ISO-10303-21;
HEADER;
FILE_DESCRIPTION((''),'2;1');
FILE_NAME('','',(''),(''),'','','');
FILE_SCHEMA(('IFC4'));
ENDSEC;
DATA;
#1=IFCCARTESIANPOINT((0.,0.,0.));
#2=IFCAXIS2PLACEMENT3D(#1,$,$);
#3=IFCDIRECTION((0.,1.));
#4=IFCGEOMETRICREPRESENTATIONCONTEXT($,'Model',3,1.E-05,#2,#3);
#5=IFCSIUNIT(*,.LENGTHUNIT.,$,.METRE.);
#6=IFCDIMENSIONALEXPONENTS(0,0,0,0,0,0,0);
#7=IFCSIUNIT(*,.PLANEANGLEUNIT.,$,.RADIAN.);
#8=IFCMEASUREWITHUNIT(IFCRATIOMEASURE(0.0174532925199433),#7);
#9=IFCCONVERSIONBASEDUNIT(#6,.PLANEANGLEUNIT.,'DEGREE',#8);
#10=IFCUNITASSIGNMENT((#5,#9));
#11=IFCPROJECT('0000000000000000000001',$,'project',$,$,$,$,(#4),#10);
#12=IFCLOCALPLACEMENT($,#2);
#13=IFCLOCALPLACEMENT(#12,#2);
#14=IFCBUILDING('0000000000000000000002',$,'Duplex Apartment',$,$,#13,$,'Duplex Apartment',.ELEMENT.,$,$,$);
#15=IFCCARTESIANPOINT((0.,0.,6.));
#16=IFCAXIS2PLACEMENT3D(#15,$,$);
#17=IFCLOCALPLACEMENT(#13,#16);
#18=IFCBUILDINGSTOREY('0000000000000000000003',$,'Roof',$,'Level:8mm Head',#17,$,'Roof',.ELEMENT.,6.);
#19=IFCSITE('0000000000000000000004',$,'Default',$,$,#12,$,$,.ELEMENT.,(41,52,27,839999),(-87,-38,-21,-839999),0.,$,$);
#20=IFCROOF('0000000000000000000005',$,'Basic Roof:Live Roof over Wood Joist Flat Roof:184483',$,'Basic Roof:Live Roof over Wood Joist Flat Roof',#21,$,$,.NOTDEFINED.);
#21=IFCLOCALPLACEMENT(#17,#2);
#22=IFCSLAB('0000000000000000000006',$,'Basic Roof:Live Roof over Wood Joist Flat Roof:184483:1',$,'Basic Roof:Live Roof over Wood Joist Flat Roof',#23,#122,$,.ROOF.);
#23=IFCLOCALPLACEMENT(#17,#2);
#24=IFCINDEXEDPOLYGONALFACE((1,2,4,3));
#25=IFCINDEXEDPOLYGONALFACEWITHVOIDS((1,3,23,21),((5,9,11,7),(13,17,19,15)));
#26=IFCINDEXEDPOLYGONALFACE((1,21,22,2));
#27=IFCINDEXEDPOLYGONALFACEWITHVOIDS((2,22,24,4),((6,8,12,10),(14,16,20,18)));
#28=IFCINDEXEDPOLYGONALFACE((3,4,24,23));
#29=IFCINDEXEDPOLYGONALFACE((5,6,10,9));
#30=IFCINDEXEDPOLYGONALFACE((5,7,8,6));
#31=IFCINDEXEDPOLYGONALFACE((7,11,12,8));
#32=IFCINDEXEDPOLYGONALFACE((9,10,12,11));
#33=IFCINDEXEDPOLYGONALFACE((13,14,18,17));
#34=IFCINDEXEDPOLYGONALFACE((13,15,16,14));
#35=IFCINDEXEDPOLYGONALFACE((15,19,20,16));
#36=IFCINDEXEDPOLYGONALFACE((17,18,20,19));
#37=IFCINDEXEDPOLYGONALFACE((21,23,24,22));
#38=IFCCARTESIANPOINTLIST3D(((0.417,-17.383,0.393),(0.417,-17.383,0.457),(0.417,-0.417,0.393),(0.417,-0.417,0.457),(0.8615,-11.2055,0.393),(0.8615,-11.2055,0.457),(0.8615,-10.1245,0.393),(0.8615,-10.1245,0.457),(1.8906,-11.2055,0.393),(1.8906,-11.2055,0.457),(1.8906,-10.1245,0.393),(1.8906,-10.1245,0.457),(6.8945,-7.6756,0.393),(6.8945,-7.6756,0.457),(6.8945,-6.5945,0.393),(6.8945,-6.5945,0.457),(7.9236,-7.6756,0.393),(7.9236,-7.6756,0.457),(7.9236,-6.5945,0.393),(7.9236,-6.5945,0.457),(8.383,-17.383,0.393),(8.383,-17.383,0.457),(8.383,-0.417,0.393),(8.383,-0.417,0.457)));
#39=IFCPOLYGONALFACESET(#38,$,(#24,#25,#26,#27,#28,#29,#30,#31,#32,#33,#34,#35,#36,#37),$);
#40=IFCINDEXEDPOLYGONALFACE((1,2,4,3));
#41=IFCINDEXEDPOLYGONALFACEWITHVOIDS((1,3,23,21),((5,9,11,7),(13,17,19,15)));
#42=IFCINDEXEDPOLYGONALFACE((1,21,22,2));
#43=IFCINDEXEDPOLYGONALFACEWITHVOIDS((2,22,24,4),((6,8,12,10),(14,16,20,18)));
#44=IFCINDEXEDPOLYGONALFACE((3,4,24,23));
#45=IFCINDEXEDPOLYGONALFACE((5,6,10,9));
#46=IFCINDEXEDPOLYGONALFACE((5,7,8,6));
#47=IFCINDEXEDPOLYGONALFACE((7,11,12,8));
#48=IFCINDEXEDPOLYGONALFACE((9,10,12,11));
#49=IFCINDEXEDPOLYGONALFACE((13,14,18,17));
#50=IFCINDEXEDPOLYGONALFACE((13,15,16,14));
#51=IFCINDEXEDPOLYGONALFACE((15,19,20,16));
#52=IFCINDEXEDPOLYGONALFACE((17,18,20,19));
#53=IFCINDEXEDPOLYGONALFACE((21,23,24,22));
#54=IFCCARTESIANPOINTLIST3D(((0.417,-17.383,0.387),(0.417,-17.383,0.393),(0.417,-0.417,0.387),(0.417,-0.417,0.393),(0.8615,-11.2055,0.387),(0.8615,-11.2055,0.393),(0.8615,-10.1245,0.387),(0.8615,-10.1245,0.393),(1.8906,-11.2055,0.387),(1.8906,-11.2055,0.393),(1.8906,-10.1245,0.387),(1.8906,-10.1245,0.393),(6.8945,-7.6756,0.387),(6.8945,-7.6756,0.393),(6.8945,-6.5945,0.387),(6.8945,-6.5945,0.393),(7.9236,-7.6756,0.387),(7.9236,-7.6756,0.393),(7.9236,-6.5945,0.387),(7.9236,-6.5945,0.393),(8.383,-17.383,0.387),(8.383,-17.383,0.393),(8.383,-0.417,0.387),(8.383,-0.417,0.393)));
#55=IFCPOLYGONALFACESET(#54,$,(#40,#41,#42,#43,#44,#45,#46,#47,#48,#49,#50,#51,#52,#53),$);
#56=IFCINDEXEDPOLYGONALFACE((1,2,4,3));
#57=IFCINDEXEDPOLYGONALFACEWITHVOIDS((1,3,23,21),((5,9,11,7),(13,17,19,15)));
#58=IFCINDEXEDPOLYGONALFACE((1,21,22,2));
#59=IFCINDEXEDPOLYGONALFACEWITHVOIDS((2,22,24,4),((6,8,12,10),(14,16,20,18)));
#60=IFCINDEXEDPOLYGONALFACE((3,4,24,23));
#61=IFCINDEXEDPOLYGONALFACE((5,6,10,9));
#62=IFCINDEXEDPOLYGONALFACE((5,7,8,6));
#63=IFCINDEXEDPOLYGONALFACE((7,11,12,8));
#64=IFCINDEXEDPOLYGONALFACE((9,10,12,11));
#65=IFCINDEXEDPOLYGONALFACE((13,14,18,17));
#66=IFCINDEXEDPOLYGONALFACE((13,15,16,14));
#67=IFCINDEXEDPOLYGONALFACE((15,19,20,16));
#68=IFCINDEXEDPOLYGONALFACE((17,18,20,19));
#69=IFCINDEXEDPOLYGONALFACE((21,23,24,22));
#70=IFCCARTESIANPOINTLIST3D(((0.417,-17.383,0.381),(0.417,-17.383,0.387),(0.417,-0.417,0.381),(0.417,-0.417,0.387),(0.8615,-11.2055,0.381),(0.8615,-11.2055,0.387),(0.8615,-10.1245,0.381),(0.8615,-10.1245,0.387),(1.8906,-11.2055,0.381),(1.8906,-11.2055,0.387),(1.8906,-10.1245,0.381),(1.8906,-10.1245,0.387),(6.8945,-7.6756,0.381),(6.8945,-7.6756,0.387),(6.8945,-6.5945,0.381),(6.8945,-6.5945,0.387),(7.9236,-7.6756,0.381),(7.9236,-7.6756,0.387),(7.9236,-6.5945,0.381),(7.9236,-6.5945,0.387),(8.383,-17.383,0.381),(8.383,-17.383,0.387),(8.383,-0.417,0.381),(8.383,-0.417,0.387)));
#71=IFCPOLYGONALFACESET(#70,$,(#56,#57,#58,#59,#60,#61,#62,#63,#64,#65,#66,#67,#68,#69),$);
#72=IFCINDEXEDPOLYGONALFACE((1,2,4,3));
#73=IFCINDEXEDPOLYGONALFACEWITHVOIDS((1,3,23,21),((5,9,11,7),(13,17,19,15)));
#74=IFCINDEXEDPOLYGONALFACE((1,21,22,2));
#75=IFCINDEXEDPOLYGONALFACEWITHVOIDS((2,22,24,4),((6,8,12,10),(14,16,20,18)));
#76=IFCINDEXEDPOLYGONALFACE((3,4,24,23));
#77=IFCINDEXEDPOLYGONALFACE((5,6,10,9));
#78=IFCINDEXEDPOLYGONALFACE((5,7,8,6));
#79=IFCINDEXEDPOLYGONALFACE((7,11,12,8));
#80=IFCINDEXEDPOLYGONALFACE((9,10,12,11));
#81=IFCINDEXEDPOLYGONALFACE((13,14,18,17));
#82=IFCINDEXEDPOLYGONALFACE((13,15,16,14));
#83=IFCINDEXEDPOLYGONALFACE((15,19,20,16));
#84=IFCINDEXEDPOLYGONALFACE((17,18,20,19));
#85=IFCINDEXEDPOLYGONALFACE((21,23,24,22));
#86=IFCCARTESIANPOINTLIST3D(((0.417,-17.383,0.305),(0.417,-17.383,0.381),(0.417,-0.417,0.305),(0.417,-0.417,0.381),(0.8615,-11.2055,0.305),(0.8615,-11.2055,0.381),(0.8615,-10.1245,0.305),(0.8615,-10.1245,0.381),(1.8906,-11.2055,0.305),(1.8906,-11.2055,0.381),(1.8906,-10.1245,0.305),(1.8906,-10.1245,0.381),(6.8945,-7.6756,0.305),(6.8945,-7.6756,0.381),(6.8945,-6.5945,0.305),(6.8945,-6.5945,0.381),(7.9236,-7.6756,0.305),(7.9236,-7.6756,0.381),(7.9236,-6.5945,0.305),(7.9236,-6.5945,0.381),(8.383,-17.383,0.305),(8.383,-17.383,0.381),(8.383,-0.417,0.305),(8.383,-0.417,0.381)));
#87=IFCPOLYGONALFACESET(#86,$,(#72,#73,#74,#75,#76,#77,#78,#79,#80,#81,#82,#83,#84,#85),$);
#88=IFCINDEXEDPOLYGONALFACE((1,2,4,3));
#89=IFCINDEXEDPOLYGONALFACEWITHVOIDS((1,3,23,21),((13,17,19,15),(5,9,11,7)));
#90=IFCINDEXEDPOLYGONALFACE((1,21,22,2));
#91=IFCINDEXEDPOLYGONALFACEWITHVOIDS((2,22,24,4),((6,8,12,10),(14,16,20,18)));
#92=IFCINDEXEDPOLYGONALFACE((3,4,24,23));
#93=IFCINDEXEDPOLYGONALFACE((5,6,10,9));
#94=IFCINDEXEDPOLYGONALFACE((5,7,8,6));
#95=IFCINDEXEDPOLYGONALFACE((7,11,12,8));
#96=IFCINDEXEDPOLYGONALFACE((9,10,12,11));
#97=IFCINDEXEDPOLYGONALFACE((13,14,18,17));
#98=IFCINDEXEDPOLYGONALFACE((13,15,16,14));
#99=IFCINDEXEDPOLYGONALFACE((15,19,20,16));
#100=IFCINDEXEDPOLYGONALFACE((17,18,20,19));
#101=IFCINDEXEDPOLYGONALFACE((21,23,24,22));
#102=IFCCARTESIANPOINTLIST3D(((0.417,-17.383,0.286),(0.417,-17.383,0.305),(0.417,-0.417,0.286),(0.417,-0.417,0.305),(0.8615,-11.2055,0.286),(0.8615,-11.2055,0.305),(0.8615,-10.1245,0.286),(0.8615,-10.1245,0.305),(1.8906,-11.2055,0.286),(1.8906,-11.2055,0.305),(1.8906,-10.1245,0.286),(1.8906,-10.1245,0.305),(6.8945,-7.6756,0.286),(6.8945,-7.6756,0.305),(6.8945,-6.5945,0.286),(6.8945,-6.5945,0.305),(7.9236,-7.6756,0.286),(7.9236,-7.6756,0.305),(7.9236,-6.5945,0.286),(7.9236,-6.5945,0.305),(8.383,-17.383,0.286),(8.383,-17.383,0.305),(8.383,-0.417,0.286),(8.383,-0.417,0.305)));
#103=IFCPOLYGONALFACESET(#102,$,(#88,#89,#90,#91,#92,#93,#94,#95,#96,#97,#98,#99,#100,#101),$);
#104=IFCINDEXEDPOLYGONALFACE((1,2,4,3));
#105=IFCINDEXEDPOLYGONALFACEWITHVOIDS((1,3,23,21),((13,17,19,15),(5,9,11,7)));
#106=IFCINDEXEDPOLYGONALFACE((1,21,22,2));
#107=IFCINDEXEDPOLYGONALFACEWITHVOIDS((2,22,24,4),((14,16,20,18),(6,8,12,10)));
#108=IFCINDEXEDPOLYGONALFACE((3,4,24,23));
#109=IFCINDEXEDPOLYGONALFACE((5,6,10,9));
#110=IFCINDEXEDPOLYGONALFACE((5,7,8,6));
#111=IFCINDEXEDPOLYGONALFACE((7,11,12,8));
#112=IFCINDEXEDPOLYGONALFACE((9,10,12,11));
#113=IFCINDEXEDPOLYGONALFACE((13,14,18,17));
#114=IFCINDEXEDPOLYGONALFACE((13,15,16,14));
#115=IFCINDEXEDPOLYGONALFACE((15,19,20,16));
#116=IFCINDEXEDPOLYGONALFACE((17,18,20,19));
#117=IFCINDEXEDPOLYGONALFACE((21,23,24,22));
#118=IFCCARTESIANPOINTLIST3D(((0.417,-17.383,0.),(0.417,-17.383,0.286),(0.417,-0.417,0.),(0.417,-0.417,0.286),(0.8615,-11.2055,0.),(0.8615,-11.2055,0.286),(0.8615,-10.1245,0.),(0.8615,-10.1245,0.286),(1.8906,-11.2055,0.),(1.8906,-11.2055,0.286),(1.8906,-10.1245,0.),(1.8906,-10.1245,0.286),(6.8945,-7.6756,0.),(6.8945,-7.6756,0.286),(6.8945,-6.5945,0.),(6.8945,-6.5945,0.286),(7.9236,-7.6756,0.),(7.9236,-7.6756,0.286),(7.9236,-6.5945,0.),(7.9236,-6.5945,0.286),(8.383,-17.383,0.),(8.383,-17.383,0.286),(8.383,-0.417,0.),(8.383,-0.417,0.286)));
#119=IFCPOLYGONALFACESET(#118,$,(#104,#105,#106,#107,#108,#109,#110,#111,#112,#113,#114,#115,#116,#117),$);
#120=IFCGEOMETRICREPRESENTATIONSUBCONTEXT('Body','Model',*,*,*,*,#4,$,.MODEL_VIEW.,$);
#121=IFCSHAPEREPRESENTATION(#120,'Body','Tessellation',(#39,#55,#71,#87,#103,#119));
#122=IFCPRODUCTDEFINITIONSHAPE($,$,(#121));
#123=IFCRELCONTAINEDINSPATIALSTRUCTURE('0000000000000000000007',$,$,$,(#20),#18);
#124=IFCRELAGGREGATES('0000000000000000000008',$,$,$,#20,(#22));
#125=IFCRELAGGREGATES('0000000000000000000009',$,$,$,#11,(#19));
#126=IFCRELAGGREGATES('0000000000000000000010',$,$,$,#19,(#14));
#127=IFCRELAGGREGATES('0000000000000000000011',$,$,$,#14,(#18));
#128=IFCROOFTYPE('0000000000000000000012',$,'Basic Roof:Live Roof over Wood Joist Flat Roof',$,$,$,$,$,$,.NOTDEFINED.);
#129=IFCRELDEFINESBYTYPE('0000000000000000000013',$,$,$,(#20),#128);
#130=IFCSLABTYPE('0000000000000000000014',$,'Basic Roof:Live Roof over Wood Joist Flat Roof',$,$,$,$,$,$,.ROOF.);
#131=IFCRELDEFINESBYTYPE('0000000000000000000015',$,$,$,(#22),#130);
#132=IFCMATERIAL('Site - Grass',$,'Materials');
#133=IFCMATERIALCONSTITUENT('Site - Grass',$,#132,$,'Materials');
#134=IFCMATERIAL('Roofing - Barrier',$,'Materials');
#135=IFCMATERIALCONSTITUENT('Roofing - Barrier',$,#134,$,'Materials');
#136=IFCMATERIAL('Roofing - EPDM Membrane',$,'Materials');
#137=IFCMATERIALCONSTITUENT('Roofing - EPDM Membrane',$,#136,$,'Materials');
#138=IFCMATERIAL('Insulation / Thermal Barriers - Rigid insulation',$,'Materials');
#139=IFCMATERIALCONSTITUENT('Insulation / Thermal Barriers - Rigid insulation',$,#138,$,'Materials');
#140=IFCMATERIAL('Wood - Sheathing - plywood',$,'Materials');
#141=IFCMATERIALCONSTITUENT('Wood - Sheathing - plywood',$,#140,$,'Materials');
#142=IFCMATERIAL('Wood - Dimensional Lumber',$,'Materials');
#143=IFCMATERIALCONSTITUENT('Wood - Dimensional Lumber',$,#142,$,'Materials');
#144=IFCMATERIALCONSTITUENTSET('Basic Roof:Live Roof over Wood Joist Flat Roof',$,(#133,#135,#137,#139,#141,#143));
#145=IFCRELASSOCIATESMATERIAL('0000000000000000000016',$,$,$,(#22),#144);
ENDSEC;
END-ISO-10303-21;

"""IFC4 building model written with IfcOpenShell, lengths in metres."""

from ifc_helpers import new_model, entity, si_unit, converted_unit, direction, frame, origin, place, context, subcontext, project, spatial, indexed_curve, outline, extrude, material, constituent, constituent_set, type_object, element, aggregate, save


model = new_model("IFC4")

# Units and contexts
model_context = context("Model", 3, precision=1e-05, world=origin(), true_north=direction((0.0, 1.0)))
body_context = subcontext(model_context, "Body", "Model", "MODEL_VIEW")
ifc_project = project(units=[si_unit("LENGTHUNIT", "METRE"), converted_unit("PLANEANGLEUNIT", "DEGREE", entity("IfcRatioMeasure", 0.0174532925199433), si_unit("PLANEANGLEUNIT", "RADIAN"), dimensions=[0, 0, 0, 0, 0, 0, 0])], contexts=[model_context])

# Site, building, storey
site_placement = place(None, origin())
site = spatial("IfcSite", under=ifc_project, at=site_placement, Name="Default", CompositionType="ELEMENT", RefLatitude=(41, 52, 27, 839999), RefLongitude=(-87, -38, -21, -839999), RefElevation=0.0)
building_placement = place(site_placement, origin())
building = spatial("IfcBuilding", under=site, at=building_placement, Name="Duplex Apartment", LongName="Duplex Apartment", CompositionType="ELEMENT")
storey_placement = place(building_placement, frame((0.0, 0.0, 6.0)))
storey = spatial("IfcBuildingStorey", under=building, at=storey_placement, Name="Roof", ObjectType="Level:8mm Head", LongName="Roof", CompositionType="ELEMENT", Elevation=6.0)

# Roof, slab, openings
roof_type = type_object("IfcRoofType", Name="Basic Roof:Live Roof over Wood Joist Flat Roof", PredefinedType="NOTDEFINED")
roof_placement = place(storey_placement, origin())
roof = element("IfcRoof", 1, at=roof_placement, inside=storey, type_object=roof_type, Name="Basic Roof:Live Roof over Wood Joist Flat Roof:184483", ObjectType="Basic Roof:Live Roof over Wood Joist Flat Roof", PredefinedType="NOTDEFINED")
ifc_material_1 = material(Name="Site - Grass", Category="Materials")
ifc_constituent_1 = constituent(ifc_material_1, Name="Site - Grass", Category="Materials")
ifc_material_2 = material(Name="Roofing - Barrier", Category="Materials")
ifc_constituent_2 = constituent(ifc_material_2, Name="Roofing - Barrier", Category="Materials")
ifc_material_3 = material(Name="Roofing - EPDM Membrane", Category="Materials")
ifc_constituent_3 = constituent(ifc_material_3, Name="Roofing - EPDM Membrane", Category="Materials")
ifc_material_4 = material(Name="Insulation / Thermal Barriers - Rigid insulation", Category="Materials")
ifc_constituent_4 = constituent(ifc_material_4, Name="Insulation / Thermal Barriers - Rigid insulation", Category="Materials")
ifc_material_5 = material(Name="Wood - Sheathing - plywood", Category="Materials")
ifc_constituent_5 = constituent(ifc_material_5, Name="Wood - Sheathing - plywood", Category="Materials")
ifc_material_6 = material(Name="Wood - Dimensional Lumber", Category="Materials")
ifc_constituent_6 = constituent(ifc_material_6, Name="Wood - Dimensional Lumber", Category="Materials")
ifc_constituent_set_1 = constituent_set(constituents=[ifc_constituent_1, ifc_constituent_2, ifc_constituent_3, ifc_constituent_4, ifc_constituent_5, ifc_constituent_6], Name="Basic Roof:Live Roof over Wood Joist Flat Roof")
slab_type = type_object("IfcSlabType", Name="Basic Roof:Live Roof over Wood Joist Flat Roof", PredefinedType="ROOF")
slab_placement = place(storey_placement, origin())
slab = element("IfcSlab", 2, at=slab_placement, type_object=slab_type, material=ifc_constituent_set_1, Name="Basic Roof:Live Roof over Wood Joist Flat Roof:184483:1", ObjectType="Basic Roof:Live Roof over Wood Joist Flat Roof", PredefinedType="ROOF", context=body_context, shape_type="SweptSolid", body=[
    extrude(outline(indexed_curve([(-8.483, -3.983), (8.483, -3.983), (8.483, 3.983), (-8.483, 3.983), (-8.483, -3.983)], self_intersect=False)), frame((4.4, -8.9, 0.393), z_axis=(0.0, 0.0, 1.0), x_axis=(0.0, -1.0, 0.0)), (0.0, 0.0, 1.0), 0.064),
    extrude(outline(indexed_curve([(-8.483, -3.983), (8.483, -3.983), (8.483, 3.983), (-8.483, 3.983), (-8.483, -3.983)], self_intersect=False)), frame((4.4, -8.9, 0.387), z_axis=(0.0, 0.0, 1.0), x_axis=(0.0, -1.0, 0.0)), (0.0, 0.0, 1.0), 0.006),
    extrude(outline(indexed_curve([(-8.483, -3.983), (8.483, -3.983), (8.483, 3.983), (-8.483, 3.983), (-8.483, -3.983)], self_intersect=False)), frame((4.4, -8.9, 0.381), z_axis=(0.0, 0.0, 1.0), x_axis=(0.0, -1.0, 0.0)), (0.0, 0.0, 1.0), 0.006),
    extrude(outline(indexed_curve([(-8.483, -3.983), (8.483, -3.983), (8.483, 3.983), (-8.483, 3.983), (-8.483, -3.983)], self_intersect=False)), frame((4.4, -8.9, 0.305), z_axis=(0.0, 0.0, 1.0), x_axis=(0.0, -1.0, 0.0)), (0.0, 0.0, 1.0), 0.076),
    extrude(outline(indexed_curve([(-8.483, -3.983), (8.483, -3.983), (8.483, 3.983), (-8.483, 3.983), (-8.483, -3.983)], self_intersect=False)), frame((4.4, -8.9, 0.286), z_axis=(0.0, 0.0, 1.0), x_axis=(0.0, -1.0, 0.0)), (0.0, 0.0, 1.0), 0.019),
    extrude(outline(indexed_curve([(-8.483, -3.983), (8.483, -3.983), (8.483, 3.983), (-8.483, 3.983), (-8.483, -3.983)], self_intersect=False)), frame((4.4, -8.9, 0.0), z_axis=(0.0, 0.0, 1.0), x_axis=(0.0, -1.0, 0.0)), (0.0, 0.0, 1.0), 0.286),
])
opening_1_placement = place(storey_placement, origin())
element("IfcOpeningElement", 3, at=opening_1_placement, cuts=slab, ObjectType="Opening", PredefinedType="OPENING", context=body_context, shape_type="SweptSolid", body=[
    extrude(outline(indexed_curve([(-0.5145, -0.5405), (0.5145, -0.5405), (0.5145, 0.5405), (-0.5145, 0.5405), (-0.5145, -0.5405)], self_intersect=False)), frame((1.376, -10.665, 0.0), z_axis=(0.0, 0.0, 1.0), x_axis=(-1.0, 0.0, 0.0)), (0.0, 0.0, 1.0), 0.286),
])
opening_2_placement = place(storey_placement, origin())
element("IfcOpeningElement", 4, at=opening_2_placement, cuts=slab, ObjectType="Opening", PredefinedType="OPENING", context=body_context, shape_type="SweptSolid", body=[
    extrude(outline(indexed_curve([(-0.5145, -0.5405), (0.5145, -0.5405), (0.5145, 0.5405), (-0.5145, 0.5405), (-0.5145, -0.5405)], self_intersect=False)), frame((7.409, -7.135, 0.0), z_axis=(0.0, 0.0, 1.0), x_axis=(-1.0, 0.0, 0.0)), (0.0, 0.0, 1.0), 0.286),
])
opening_3_placement = place(storey_placement, origin())
element("IfcOpeningElement", 5, at=opening_3_placement, cuts=slab, ObjectType="Opening", PredefinedType="OPENING", context=body_context, shape_type="SweptSolid", body=[
    extrude(outline(indexed_curve([(-0.5405, -0.5145), (0.5405, -0.5145), (0.5405, 0.5145), (-0.5405, 0.5145), (-0.5405, -0.5145)], self_intersect=False)), frame((7.409, -7.135, 0.286), z_axis=(0.0, 0.0, 1.0), x_axis=(0.0, 1.0, 0.0)), (0.0, 0.0, 1.0), 0.019),
])
opening_4_placement = place(storey_placement, origin())
element("IfcOpeningElement", 6, at=opening_4_placement, cuts=slab, ObjectType="Opening", PredefinedType="OPENING", context=body_context, shape_type="SweptSolid", body=[
    extrude(outline(indexed_curve([(-0.5405, -0.5145), (0.5405, -0.5145), (0.5405, 0.5145), (-0.5405, 0.5145), (-0.5405, -0.5145)], self_intersect=False)), frame((1.376, -10.665, 0.286), z_axis=(0.0, 0.0, 1.0), x_axis=(0.0, 1.0, 0.0)), (0.0, 0.0, 1.0), 0.019),
])
opening_5_placement = place(storey_placement, origin())
element("IfcOpeningElement", 7, at=opening_5_placement, cuts=slab, ObjectType="Opening", PredefinedType="OPENING", context=body_context, shape_type="SweptSolid", body=[
    extrude(outline(indexed_curve([(-0.5405, -0.5145), (0.5405, -0.5145), (0.5405, 0.5145), (-0.5405, 0.5145), (-0.5405, -0.5145)], self_intersect=False)), frame((7.409, -7.135, 0.305), z_axis=(0.0, 0.0, 1.0), x_axis=(0.0, 1.0, 0.0)), (0.0, 0.0, 1.0), 0.076),
])
opening_6_placement = place(storey_placement, origin())
element("IfcOpeningElement", 8, at=opening_6_placement, cuts=slab, ObjectType="Opening", PredefinedType="OPENING", context=body_context, shape_type="SweptSolid", body=[
    extrude(outline(indexed_curve([(-0.5405, -0.5145), (0.5405, -0.5145), (0.5405, 0.5145), (-0.5405, 0.5145), (-0.5405, -0.5145)], self_intersect=False)), frame((1.376, -10.665, 0.305), z_axis=(0.0, 0.0, 1.0), x_axis=(0.0, 1.0, 0.0)), (0.0, 0.0, 1.0), 0.076),
])
opening_7_placement = place(storey_placement, origin())
element("IfcOpeningElement", 9, at=opening_7_placement, cuts=slab, ObjectType="Opening", PredefinedType="OPENING", context=body_context, shape_type="SweptSolid", body=[
    extrude(outline(indexed_curve([(-0.5405, -0.5145), (0.5405, -0.5145), (0.5405, 0.5145), (-0.5405, 0.5145), (-0.5405, -0.5145)], self_intersect=False)), frame((7.409, -7.135, 0.381), z_axis=(0.0, 0.0, 1.0), x_axis=(0.0, 1.0, 0.0)), (0.0, 0.0, 1.0), 0.006),
])
opening_8_placement = place(storey_placement, origin())
element("IfcOpeningElement", 10, at=opening_8_placement, cuts=slab, ObjectType="Opening", PredefinedType="OPENING", context=body_context, shape_type="SweptSolid", body=[
    extrude(outline(indexed_curve([(-0.5405, -0.5145), (0.5405, -0.5145), (0.5405, 0.5145), (-0.5405, 0.5145), (-0.5405, -0.5145)], self_intersect=False)), frame((1.376, -10.665, 0.381), z_axis=(0.0, 0.0, 1.0), x_axis=(0.0, 1.0, 0.0)), (0.0, 0.0, 1.0), 0.006),
])
opening_9_placement = place(storey_placement, origin())
element("IfcOpeningElement", 11, at=opening_9_placement, cuts=slab, ObjectType="Opening", PredefinedType="OPENING", context=body_context, shape_type="SweptSolid", body=[
    extrude(outline(indexed_curve([(-0.5405, -0.5145), (0.5405, -0.5145), (0.5405, 0.5145), (-0.5405, 0.5145), (-0.5405, -0.5145)], self_intersect=False)), frame((7.409, -7.135, 0.387), z_axis=(0.0, 0.0, 1.0), x_axis=(0.0, 1.0, 0.0)), (0.0, 0.0, 1.0), 0.006),
])
opening_10_placement = place(storey_placement, origin())
element("IfcOpeningElement", 12, at=opening_10_placement, cuts=slab, ObjectType="Opening", PredefinedType="OPENING", context=body_context, shape_type="SweptSolid", body=[
    extrude(outline(indexed_curve([(-0.5405, -0.5145), (0.5405, -0.5145), (0.5405, 0.5145), (-0.5405, 0.5145), (-0.5405, -0.5145)], self_intersect=False)), frame((1.376, -10.665, 0.387), z_axis=(0.0, 0.0, 1.0), x_axis=(0.0, 1.0, 0.0)), (0.0, 0.0, 1.0), 0.006),
])
opening_11_placement = place(storey_placement, origin())
element("IfcOpeningElement", 13, at=opening_11_placement, cuts=slab, ObjectType="Opening", PredefinedType="OPENING", context=body_context, shape_type="SweptSolid", body=[
    extrude(outline(indexed_curve([(-0.5405, -0.5145), (0.5405, -0.5145), (0.5405, 0.5145), (-0.5405, 0.5145), (-0.5405, -0.5145)], self_intersect=False)), frame((7.409, -7.135, 0.393), z_axis=(0.0, 0.0, 1.0), x_axis=(0.0, 1.0, 0.0)), (0.0, 0.0, 1.0), 0.064),
])
opening_12_placement = place(storey_placement, origin())
element("IfcOpeningElement", 14, at=opening_12_placement, cuts=slab, ObjectType="Opening", PredefinedType="OPENING", context=body_context, shape_type="SweptSolid", body=[
    extrude(outline(indexed_curve([(-0.5405, -0.5145), (0.5405, -0.5145), (0.5405, 0.5145), (-0.5405, 0.5145), (-0.5405, -0.5145)], self_intersect=False)), frame((1.376, -10.665, 0.393), z_axis=(0.0, 0.0, 1.0), x_axis=(0.0, 1.0, 0.0)), (0.0, 0.0, 1.0), 0.064),
])
aggregate(roof, [slab])

save(model, "model.ifc")
